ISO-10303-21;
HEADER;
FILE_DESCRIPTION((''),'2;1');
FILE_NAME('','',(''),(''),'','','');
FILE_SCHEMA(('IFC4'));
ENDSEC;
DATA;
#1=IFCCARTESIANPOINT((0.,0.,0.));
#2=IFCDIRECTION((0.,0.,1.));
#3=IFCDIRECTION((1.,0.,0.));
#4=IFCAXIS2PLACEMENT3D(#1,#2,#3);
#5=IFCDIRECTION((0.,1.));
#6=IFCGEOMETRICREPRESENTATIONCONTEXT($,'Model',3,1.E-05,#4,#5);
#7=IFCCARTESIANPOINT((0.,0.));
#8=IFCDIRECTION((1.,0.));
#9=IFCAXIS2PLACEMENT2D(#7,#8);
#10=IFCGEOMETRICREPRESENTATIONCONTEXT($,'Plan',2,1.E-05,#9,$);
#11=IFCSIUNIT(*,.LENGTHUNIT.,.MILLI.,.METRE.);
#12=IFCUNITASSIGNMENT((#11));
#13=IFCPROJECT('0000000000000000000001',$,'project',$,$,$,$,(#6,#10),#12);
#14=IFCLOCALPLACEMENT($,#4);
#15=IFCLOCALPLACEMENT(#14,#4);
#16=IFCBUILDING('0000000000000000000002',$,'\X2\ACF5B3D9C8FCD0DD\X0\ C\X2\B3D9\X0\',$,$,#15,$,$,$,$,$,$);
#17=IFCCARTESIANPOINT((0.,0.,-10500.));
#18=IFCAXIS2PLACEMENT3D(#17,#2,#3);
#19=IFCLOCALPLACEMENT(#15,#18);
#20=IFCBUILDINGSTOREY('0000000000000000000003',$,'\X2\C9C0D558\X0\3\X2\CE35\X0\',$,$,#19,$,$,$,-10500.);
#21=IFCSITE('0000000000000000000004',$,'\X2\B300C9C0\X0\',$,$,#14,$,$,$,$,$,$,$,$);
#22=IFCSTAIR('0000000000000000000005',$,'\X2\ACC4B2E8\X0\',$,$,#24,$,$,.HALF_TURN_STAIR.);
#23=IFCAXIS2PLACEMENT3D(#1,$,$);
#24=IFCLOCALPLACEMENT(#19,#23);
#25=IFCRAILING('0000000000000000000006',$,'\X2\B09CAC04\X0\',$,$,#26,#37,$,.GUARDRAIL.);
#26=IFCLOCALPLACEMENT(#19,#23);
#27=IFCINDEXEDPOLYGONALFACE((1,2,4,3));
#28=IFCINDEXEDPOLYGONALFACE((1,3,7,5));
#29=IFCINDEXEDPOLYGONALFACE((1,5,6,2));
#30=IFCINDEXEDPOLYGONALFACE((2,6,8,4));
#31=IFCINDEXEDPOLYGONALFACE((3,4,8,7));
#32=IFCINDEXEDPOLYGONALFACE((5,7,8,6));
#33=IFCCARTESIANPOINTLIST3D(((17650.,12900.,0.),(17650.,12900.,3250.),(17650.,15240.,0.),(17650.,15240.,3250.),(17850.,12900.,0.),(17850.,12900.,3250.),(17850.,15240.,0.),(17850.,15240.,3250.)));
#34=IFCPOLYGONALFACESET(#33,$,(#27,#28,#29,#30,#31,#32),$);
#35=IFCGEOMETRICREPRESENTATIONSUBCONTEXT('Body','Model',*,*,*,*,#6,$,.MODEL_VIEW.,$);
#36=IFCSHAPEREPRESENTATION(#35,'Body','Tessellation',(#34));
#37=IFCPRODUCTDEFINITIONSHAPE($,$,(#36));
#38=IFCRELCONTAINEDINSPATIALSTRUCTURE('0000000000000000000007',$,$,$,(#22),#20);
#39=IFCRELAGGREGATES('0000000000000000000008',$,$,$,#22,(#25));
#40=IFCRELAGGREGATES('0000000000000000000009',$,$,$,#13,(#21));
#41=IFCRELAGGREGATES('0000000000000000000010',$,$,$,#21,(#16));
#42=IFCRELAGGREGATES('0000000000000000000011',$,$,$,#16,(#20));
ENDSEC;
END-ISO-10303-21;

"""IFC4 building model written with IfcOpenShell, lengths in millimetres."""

from ifc_helpers import new_model, si_unit, direction, frame, origin_with_axes, origin_2d_with_axis, place, context, subcontext, project, spatial, polyline, outline, extrude, element, aggregate, save


model = new_model("IFC4")

# Units and contexts
model_context = context("Model", 3, precision=1e-05, world=origin_with_axes(), true_north=direction((0.0, 1.0)))
plan_context = context("Plan", 2, precision=1e-05, world=origin_2d_with_axis())
body_context = subcontext(model_context, "Body", "Model", "MODEL_VIEW")
ifc_project = project(units=[si_unit("LENGTHUNIT", "METRE", prefix="MILLI")], contexts=[model_context, plan_context])

# Site, building, storey
site_placement = place(None, origin_with_axes())
site = spatial("IfcSite", under=ifc_project, at=site_placement, Name="대지")
building_placement = place(site_placement, origin_with_axes())
building = spatial("IfcBuilding", under=site, at=building_placement, Name="공동주택 C동")
storey_placement = place(building_placement, frame((0.0, 0.0, -10500.0), z_axis=(0.0, 0.0, 1.0), x_axis=(1.0, 0.0, 0.0)))
storey = spatial("IfcBuildingStorey", under=building, at=storey_placement, Name="지하3층", Elevation=-10500.0)

# Stair
stair_placement = place(storey_placement, origin_with_axes())
stair = element("IfcStair", 1, at=stair_placement, inside=storey, Name="계단", PredefinedType="HALF_TURN_STAIR")

# Railing
railing_placement = place(stair_placement, origin_with_axes())
railing = element("IfcRailing", 2, at=railing_placement, Name="난간", PredefinedType="GUARDRAIL", context=body_context, shape_type="SweptSolid", body=[
    extrude(outline(polyline([(17650.0, 12900.0), (17850.0, 12900.0), (17850.0, 15240.0), (17650.0, 15240.0), (17650.0, 12900.0)])), origin_with_axes(), (0.0, 0.0, 1.0), 3250.0),
])
aggregate(stair, [railing])

save(model, "model.ifc")
